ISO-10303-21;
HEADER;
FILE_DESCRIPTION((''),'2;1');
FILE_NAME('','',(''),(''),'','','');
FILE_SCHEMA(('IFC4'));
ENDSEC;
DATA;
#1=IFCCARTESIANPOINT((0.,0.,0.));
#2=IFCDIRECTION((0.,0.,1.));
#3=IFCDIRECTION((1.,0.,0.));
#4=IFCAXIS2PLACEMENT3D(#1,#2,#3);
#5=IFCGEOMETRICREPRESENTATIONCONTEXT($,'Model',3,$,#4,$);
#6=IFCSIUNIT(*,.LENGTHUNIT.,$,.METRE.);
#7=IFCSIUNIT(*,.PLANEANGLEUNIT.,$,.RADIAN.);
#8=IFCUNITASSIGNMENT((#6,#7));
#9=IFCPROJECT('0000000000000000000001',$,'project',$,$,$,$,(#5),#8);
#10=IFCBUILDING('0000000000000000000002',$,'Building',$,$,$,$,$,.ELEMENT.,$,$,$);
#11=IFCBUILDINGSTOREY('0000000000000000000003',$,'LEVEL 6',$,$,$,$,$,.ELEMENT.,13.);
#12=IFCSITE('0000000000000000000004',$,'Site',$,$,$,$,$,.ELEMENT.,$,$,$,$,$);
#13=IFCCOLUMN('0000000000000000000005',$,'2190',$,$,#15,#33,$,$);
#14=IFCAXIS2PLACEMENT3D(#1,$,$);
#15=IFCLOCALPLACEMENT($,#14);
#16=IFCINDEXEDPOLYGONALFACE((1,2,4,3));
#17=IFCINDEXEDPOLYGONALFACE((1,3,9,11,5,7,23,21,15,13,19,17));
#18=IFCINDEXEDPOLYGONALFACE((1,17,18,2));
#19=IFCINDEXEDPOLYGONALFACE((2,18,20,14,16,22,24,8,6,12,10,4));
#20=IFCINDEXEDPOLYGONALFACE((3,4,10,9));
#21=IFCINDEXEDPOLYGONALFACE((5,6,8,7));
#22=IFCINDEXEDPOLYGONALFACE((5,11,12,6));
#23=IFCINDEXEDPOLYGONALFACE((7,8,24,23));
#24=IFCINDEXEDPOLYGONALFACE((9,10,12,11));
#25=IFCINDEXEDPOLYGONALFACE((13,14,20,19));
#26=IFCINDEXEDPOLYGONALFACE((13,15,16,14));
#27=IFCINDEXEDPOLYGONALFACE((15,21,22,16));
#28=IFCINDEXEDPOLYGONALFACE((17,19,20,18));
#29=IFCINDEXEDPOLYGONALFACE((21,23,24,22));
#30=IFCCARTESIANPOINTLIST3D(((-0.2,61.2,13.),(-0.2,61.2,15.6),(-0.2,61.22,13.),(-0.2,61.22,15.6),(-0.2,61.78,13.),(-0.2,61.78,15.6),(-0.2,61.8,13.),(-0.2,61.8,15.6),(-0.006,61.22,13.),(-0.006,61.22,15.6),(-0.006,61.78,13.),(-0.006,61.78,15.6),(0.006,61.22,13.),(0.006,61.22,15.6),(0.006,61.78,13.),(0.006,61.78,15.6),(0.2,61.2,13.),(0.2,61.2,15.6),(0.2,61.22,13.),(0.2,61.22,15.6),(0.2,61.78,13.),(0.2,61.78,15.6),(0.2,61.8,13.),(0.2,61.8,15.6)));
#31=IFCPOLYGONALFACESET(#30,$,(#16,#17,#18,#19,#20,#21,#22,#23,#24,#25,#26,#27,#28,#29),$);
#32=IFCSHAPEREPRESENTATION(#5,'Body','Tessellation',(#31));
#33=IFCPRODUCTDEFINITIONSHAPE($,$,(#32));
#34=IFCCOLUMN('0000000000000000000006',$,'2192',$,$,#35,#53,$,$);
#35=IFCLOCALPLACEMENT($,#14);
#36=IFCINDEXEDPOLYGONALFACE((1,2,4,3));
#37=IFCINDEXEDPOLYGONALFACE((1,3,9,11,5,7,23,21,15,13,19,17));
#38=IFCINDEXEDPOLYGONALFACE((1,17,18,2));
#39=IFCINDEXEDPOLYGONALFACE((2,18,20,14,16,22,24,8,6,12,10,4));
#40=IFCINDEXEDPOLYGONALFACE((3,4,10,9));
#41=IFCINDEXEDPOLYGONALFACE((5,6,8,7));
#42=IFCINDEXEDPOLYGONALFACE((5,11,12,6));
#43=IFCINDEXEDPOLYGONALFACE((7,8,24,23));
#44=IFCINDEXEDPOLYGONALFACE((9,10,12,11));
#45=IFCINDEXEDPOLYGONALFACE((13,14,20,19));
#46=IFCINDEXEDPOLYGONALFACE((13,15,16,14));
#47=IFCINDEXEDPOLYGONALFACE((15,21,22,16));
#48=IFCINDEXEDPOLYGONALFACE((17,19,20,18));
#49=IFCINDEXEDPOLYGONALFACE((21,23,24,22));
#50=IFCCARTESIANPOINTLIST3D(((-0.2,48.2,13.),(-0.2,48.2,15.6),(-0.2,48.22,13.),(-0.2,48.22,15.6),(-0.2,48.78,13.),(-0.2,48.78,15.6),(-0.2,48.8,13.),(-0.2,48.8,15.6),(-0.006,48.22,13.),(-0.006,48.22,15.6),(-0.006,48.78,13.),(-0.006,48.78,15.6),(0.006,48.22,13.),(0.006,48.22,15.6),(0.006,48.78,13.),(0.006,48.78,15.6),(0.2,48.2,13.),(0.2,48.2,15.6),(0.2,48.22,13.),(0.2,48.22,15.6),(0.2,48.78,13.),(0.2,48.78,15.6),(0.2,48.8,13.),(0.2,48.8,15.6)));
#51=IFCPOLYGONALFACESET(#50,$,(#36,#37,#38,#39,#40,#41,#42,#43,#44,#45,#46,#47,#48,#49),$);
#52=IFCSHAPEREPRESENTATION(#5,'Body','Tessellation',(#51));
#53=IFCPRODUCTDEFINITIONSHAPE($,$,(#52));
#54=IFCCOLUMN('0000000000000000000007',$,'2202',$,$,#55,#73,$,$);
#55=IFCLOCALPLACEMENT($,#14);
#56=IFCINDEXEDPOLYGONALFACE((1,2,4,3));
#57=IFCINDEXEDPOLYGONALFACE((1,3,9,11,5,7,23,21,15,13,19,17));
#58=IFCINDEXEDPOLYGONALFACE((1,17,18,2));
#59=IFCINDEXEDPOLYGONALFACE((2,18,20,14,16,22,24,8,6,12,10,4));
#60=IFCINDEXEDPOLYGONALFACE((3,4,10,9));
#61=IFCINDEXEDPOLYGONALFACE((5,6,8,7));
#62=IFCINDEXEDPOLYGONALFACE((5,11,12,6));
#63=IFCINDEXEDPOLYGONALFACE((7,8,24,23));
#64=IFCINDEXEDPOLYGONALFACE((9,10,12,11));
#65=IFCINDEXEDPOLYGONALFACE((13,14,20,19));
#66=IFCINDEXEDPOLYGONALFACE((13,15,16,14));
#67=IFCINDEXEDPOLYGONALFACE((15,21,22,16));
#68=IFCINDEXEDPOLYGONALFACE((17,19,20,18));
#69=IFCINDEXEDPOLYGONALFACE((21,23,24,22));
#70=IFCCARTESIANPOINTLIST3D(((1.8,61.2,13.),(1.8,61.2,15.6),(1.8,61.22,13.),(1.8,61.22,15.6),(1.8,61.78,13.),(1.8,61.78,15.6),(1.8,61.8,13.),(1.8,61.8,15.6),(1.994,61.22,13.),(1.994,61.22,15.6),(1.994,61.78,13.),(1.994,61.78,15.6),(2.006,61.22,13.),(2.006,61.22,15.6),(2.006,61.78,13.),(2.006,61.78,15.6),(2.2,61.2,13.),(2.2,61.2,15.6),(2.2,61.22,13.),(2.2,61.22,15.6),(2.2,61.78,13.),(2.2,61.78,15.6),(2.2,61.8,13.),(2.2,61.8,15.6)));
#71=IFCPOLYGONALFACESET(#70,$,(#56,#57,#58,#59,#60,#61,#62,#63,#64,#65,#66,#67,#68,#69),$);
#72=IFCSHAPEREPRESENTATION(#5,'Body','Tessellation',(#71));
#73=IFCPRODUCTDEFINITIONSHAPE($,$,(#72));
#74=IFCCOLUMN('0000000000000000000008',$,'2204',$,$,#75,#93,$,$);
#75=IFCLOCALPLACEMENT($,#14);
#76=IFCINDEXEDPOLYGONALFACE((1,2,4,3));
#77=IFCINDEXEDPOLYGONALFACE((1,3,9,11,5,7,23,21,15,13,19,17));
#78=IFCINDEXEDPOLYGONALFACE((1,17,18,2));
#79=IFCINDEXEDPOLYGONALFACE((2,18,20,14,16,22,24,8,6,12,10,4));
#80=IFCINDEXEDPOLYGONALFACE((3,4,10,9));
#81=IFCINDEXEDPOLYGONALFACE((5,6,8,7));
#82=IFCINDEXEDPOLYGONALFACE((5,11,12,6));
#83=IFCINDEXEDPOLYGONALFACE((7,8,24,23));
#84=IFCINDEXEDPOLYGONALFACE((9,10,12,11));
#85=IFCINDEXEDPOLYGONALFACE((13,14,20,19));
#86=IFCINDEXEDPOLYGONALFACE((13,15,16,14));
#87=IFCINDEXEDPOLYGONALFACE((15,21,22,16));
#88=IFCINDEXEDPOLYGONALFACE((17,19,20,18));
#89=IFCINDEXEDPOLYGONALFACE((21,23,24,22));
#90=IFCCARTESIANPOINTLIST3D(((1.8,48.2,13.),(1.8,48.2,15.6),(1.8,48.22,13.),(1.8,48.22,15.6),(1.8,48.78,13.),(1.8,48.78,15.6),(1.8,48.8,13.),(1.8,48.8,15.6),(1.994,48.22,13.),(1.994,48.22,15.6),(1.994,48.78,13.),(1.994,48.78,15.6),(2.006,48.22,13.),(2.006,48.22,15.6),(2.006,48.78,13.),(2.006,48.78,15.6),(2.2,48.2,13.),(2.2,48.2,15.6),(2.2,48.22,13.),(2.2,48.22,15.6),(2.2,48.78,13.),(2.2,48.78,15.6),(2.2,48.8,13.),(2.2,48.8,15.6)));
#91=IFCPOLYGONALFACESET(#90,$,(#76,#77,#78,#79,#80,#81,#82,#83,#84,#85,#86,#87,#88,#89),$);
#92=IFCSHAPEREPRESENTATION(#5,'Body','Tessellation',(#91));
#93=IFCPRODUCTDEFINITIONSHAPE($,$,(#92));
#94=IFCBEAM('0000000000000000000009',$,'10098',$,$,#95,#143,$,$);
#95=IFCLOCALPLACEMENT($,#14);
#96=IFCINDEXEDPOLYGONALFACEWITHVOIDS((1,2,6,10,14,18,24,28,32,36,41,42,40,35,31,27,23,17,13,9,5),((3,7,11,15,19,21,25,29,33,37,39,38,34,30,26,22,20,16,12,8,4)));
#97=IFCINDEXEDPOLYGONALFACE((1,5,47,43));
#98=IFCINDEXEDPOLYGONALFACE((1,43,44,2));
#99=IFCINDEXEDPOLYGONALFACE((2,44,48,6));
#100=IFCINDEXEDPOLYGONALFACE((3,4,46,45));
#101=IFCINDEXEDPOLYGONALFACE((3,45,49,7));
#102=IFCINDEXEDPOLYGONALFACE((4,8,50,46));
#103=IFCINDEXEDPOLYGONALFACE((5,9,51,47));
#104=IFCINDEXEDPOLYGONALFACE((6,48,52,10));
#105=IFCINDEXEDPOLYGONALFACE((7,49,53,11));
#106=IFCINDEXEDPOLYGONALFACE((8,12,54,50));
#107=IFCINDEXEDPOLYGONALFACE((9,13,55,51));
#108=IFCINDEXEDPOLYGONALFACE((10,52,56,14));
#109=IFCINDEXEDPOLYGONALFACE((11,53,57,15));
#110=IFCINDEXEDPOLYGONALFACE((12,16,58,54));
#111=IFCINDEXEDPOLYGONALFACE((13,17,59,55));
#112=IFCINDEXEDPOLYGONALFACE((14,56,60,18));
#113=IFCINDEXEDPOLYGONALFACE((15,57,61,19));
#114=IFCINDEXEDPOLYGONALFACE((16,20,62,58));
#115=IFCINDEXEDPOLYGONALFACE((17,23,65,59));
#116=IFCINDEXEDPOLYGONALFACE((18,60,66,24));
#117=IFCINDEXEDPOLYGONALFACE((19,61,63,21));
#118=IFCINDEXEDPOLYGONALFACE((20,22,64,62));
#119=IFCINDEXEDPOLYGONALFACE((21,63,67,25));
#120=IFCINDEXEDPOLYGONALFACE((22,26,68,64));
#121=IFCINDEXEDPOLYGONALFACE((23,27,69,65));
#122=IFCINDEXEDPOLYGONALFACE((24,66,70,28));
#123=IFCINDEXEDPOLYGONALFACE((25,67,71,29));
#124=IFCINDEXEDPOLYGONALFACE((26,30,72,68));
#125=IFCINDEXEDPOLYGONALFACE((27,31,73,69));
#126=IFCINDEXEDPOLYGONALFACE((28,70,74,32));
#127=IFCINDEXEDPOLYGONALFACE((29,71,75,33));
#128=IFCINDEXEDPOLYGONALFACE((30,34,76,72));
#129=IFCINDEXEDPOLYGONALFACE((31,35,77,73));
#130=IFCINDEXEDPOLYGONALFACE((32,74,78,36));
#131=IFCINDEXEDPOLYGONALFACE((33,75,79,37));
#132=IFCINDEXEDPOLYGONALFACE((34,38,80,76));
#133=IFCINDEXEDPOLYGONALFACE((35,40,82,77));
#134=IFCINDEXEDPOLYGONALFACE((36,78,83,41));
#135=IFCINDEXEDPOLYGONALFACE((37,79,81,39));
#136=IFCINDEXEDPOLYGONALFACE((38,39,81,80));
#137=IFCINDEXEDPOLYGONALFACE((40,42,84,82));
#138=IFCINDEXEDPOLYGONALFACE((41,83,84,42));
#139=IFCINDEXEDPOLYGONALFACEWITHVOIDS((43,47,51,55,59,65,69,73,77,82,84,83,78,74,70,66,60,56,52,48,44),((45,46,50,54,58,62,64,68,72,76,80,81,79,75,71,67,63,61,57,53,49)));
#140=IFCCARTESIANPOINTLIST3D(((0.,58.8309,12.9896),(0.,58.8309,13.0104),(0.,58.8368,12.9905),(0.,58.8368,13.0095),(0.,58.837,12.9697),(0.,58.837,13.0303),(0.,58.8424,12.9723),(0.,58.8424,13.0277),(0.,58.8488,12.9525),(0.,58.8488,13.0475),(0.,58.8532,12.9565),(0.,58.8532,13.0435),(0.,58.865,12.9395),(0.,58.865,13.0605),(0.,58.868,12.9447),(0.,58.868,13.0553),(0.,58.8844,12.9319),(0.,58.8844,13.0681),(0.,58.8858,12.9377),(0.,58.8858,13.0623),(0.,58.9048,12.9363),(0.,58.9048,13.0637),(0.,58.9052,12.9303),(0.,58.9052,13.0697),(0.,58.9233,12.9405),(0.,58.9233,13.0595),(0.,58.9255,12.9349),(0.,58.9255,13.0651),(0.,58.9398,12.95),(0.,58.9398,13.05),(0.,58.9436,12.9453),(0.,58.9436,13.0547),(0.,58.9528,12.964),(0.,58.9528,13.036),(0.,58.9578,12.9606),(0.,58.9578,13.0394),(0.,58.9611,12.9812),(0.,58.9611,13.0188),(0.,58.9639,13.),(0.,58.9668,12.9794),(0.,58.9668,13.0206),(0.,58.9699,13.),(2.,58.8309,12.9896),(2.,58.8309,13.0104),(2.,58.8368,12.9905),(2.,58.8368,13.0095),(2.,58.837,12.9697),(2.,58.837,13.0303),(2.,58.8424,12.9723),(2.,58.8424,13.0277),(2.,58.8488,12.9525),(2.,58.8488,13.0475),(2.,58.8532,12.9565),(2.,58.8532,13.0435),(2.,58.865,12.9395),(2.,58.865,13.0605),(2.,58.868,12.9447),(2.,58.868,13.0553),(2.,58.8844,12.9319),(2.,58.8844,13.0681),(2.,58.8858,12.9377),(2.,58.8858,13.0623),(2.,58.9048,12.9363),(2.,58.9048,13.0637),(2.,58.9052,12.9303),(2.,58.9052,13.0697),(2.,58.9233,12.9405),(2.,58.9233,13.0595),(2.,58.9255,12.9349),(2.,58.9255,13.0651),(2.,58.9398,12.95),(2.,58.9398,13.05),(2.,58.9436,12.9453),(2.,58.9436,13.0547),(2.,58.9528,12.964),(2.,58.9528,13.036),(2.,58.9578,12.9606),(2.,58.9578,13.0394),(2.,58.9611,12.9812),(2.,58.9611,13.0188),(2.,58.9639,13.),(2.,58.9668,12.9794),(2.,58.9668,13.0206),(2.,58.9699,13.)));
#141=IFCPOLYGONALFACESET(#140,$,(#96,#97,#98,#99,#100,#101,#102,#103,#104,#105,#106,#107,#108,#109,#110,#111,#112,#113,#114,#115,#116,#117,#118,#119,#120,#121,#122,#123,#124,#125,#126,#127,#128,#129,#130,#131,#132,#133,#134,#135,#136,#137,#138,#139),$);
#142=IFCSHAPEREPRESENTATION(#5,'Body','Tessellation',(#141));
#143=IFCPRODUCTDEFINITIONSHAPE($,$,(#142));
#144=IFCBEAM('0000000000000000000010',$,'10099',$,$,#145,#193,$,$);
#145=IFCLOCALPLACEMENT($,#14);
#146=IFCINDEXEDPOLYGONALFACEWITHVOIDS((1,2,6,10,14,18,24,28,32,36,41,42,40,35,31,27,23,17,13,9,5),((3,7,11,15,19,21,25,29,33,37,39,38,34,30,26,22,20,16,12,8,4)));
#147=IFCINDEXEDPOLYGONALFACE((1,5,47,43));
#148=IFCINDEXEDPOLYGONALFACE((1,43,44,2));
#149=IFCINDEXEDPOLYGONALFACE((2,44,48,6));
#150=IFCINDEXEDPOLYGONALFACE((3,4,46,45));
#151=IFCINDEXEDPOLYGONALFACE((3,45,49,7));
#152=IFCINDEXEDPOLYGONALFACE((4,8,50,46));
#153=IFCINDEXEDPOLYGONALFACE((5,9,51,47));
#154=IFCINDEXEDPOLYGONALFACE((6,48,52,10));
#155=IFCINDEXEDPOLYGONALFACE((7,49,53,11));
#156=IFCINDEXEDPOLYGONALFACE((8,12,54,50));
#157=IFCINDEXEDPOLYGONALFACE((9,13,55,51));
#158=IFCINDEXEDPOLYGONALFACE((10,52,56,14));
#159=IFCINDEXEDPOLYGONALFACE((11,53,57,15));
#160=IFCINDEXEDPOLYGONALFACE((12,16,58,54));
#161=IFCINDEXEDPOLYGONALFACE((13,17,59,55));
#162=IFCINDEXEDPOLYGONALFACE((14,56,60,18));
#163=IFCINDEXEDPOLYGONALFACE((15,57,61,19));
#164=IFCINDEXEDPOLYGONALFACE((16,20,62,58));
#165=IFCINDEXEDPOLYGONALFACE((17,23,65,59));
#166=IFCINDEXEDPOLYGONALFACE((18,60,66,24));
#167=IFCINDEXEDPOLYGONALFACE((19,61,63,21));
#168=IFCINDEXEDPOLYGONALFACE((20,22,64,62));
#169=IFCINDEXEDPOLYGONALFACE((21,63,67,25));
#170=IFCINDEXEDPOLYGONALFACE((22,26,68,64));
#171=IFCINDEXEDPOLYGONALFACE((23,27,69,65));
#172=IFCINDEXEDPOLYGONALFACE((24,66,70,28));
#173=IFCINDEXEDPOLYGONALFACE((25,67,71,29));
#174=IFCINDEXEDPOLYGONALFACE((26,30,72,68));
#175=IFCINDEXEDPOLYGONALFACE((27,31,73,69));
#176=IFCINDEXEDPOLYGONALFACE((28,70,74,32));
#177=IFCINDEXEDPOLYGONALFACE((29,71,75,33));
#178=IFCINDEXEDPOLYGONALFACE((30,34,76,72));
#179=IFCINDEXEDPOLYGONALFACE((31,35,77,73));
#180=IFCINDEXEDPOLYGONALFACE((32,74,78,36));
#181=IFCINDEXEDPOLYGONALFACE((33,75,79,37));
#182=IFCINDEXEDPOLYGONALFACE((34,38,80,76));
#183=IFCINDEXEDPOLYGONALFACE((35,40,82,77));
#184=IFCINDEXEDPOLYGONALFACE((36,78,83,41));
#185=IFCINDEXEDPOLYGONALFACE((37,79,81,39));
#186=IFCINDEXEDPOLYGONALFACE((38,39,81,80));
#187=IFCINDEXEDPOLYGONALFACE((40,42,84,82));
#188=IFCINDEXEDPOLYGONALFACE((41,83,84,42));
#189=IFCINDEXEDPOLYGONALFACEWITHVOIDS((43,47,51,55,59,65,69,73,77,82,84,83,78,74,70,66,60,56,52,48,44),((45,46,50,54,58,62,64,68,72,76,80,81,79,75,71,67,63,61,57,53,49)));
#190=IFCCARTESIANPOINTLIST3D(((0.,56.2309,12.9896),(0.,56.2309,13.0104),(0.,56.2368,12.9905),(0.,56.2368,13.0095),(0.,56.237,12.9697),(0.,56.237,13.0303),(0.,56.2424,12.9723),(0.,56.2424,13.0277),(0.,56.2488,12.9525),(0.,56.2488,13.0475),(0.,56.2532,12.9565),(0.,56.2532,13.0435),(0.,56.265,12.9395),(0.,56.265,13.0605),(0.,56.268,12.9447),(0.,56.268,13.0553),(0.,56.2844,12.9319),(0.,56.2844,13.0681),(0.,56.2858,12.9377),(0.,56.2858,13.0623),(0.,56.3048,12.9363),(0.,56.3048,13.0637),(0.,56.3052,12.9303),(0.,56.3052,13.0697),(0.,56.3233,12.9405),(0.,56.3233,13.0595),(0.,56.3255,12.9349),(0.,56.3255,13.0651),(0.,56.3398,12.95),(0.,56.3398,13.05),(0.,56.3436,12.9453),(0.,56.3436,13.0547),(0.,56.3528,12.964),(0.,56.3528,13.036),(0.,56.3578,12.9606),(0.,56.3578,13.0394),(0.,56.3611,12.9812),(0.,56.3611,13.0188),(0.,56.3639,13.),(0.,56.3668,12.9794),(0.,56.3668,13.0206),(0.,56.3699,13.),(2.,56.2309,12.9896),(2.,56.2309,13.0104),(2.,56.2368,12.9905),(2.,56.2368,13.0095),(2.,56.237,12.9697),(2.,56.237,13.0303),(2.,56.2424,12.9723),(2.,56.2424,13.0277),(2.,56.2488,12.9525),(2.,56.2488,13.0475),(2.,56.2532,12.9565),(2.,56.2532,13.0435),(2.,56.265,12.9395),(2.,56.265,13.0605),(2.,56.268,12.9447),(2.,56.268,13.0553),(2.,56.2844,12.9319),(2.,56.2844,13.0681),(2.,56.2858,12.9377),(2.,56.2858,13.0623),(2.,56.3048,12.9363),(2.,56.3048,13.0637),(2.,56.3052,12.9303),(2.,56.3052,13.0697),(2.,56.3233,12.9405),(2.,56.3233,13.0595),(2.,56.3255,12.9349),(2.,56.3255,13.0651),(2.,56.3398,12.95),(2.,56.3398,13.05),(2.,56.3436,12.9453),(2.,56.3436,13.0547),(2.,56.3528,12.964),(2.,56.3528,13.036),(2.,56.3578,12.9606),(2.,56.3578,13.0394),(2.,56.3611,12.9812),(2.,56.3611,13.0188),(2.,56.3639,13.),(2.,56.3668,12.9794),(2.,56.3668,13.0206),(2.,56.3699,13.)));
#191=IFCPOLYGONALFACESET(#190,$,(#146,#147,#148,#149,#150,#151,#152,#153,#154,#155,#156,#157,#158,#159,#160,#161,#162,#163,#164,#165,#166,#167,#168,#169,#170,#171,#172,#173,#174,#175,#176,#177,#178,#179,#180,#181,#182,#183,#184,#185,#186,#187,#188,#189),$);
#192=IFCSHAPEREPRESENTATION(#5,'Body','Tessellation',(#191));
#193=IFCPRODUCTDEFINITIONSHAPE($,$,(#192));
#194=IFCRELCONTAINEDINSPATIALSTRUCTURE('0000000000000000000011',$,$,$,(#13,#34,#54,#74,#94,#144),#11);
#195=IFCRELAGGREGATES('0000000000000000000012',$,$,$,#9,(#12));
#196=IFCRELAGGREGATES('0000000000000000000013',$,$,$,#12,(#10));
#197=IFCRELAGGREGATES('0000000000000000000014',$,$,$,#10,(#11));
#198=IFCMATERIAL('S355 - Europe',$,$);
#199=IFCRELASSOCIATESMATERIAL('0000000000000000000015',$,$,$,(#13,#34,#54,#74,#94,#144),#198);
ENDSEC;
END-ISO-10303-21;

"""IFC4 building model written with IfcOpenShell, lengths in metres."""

from ifc_helpers import new_model, si_unit, frame, origin_with_axes, origin_2d_with_axis, place, context, project, spatial, hollow_circle, i_section, extrude, material, material_profile, profile_set, profile_usage, element, save


model = new_model("IFC4")

# Units and contexts
model_context = context("Model", 3, world=origin_with_axes())
ifc_project = project(units=[si_unit("LENGTHUNIT", "METRE"), si_unit("PLANEANGLEUNIT", "RADIAN")], contexts=[model_context])

# Site, building, storey
site = spatial("IfcSite", under=ifc_project, Name="Site", CompositionType="ELEMENT")
building = spatial("IfcBuilding", under=site, Name="Building", CompositionType="ELEMENT")
storey = spatial("IfcBuildingStorey", under=building, Name="LEVEL 6", CompositionType="ELEMENT", Elevation=13.0)

# Columns
ifc_material = material(Name="S355 - Europe")
ifc_material_profile_1 = material_profile(ifc_material, i_section(OverallWidth=0.4, OverallDepth=0.6, WebThickness=0.012, FlangeThickness=0.02, at=origin_2d_with_axis()))
ifc_profile_set_1 = profile_set([ifc_material_profile_1])
ifc_profile_usage_1 = profile_usage(ifc_profile_set_1, cardinal=10)
column_1_placement = place(None, frame((0.0, 61.5, 13.0), z_axis=(0.0, 0.0, 1.0), x_axis=(1.0, 0.0, 0.0)))
element("IfcColumn", 1, at=column_1_placement, inside=storey, material=ifc_profile_usage_1, Name="2190", context=model_context, shape_type="SweptSolid", body=[
    extrude(i_section(OverallWidth=0.4, OverallDepth=0.6, WebThickness=0.012, FlangeThickness=0.02, at=origin_2d_with_axis()), origin_with_axes(), (0.0, 0.0, 1.0), 2.6),
])
ifc_material_profile_2 = material_profile(ifc_material, i_section(OverallWidth=0.4, OverallDepth=0.6, WebThickness=0.012, FlangeThickness=0.02, at=origin_2d_with_axis()))
ifc_profile_set_2 = profile_set([ifc_material_profile_2])
ifc_profile_usage_2 = profile_usage(ifc_profile_set_2, cardinal=10)
column_2_placement = place(None, frame((0.0, 48.5, 13.0), z_axis=(0.0, 0.0, 1.0), x_axis=(1.0, 0.0, 0.0)))
element("IfcColumn", 2, at=column_2_placement, inside=storey, material=ifc_profile_usage_2, Name="2192", context=model_context, shape_type="SweptSolid", body=[
    extrude(i_section(OverallWidth=0.4, OverallDepth=0.6, WebThickness=0.012, FlangeThickness=0.02, at=origin_2d_with_axis()), origin_with_axes(), (0.0, 0.0, 1.0), 2.6),
])
ifc_material_profile_3 = material_profile(ifc_material, i_section(OverallWidth=0.4, OverallDepth=0.6, WebThickness=0.012, FlangeThickness=0.02, at=origin_2d_with_axis()))
ifc_profile_set_3 = profile_set([ifc_material_profile_3])
ifc_profile_usage_3 = profile_usage(ifc_profile_set_3, cardinal=10)
column_3_placement = place(None, frame((2.0, 61.5, 13.0), z_axis=(0.0, 0.0, 1.0), x_axis=(1.0, 0.0, 0.0)))
element("IfcColumn", 3, at=column_3_placement, inside=storey, material=ifc_profile_usage_3, Name="2202", context=model_context, shape_type="SweptSolid", body=[
    extrude(i_section(OverallWidth=0.4, OverallDepth=0.6, WebThickness=0.012, FlangeThickness=0.02, at=origin_2d_with_axis()), origin_with_axes(), (0.0, 0.0, 1.0), 2.6),
])
ifc_material_profile_4 = material_profile(ifc_material, i_section(OverallWidth=0.4, OverallDepth=0.6, WebThickness=0.012, FlangeThickness=0.02, at=origin_2d_with_axis()))
ifc_profile_set_4 = profile_set([ifc_material_profile_4])
ifc_profile_usage_4 = profile_usage(ifc_profile_set_4, cardinal=10)
column_4_placement = place(None, frame((2.0, 48.5, 13.0), z_axis=(0.0, 0.0, 1.0), x_axis=(1.0, 0.0, 0.0)))
element("IfcColumn", 4, at=column_4_placement, inside=storey, material=ifc_profile_usage_4, Name="2204", context=model_context, shape_type="SweptSolid", body=[
    extrude(i_section(OverallWidth=0.4, OverallDepth=0.6, WebThickness=0.012, FlangeThickness=0.02, at=origin_2d_with_axis()), origin_with_axes(), (0.0, 0.0, 1.0), 2.6),
])

# Beams
ifc_material_profile_5 = material_profile(ifc_material, hollow_circle(Radius=0.0699, WallThickness=0.006, at=origin_2d_with_axis()))
ifc_profile_set_5 = profile_set([ifc_material_profile_5])
ifc_profile_usage_5 = profile_usage(ifc_profile_set_5, cardinal=10)
beam_1_placement = place(None, frame((0.0, 58.9, 13.0), z_axis=(1.0, 0.0, 0.0), x_axis=(0.0, 1.0, 0.0)))
element("IfcBeam", 5, at=beam_1_placement, inside=storey, material=ifc_profile_usage_5, Name="10098", context=model_context, shape_type="SweptSolid", body=[
    extrude(hollow_circle(Radius=0.0699, WallThickness=0.006, at=origin_2d_with_axis()), origin_with_axes(), (0.0, 0.0, 1.0), 2.0),
])
ifc_material_profile_6 = material_profile(ifc_material, hollow_circle(Radius=0.0699, WallThickness=0.006, at=origin_2d_with_axis()))
ifc_profile_set_6 = profile_set([ifc_material_profile_6])
ifc_profile_usage_6 = profile_usage(ifc_profile_set_6, cardinal=10)
beam_2_placement = place(None, frame((0.0, 56.3, 13.0), z_axis=(1.0, 0.0, 0.0), x_axis=(0.0, 1.0, 0.0)))
element("IfcBeam", 6, at=beam_2_placement, inside=storey, material=ifc_profile_usage_6, Name="10099", context=model_context, shape_type="SweptSolid", body=[
    extrude(hollow_circle(Radius=0.0699, WallThickness=0.006, at=origin_2d_with_axis()), origin_with_axes(), (0.0, 0.0, 1.0), 2.0),
])

save(model, "model.ifc")
